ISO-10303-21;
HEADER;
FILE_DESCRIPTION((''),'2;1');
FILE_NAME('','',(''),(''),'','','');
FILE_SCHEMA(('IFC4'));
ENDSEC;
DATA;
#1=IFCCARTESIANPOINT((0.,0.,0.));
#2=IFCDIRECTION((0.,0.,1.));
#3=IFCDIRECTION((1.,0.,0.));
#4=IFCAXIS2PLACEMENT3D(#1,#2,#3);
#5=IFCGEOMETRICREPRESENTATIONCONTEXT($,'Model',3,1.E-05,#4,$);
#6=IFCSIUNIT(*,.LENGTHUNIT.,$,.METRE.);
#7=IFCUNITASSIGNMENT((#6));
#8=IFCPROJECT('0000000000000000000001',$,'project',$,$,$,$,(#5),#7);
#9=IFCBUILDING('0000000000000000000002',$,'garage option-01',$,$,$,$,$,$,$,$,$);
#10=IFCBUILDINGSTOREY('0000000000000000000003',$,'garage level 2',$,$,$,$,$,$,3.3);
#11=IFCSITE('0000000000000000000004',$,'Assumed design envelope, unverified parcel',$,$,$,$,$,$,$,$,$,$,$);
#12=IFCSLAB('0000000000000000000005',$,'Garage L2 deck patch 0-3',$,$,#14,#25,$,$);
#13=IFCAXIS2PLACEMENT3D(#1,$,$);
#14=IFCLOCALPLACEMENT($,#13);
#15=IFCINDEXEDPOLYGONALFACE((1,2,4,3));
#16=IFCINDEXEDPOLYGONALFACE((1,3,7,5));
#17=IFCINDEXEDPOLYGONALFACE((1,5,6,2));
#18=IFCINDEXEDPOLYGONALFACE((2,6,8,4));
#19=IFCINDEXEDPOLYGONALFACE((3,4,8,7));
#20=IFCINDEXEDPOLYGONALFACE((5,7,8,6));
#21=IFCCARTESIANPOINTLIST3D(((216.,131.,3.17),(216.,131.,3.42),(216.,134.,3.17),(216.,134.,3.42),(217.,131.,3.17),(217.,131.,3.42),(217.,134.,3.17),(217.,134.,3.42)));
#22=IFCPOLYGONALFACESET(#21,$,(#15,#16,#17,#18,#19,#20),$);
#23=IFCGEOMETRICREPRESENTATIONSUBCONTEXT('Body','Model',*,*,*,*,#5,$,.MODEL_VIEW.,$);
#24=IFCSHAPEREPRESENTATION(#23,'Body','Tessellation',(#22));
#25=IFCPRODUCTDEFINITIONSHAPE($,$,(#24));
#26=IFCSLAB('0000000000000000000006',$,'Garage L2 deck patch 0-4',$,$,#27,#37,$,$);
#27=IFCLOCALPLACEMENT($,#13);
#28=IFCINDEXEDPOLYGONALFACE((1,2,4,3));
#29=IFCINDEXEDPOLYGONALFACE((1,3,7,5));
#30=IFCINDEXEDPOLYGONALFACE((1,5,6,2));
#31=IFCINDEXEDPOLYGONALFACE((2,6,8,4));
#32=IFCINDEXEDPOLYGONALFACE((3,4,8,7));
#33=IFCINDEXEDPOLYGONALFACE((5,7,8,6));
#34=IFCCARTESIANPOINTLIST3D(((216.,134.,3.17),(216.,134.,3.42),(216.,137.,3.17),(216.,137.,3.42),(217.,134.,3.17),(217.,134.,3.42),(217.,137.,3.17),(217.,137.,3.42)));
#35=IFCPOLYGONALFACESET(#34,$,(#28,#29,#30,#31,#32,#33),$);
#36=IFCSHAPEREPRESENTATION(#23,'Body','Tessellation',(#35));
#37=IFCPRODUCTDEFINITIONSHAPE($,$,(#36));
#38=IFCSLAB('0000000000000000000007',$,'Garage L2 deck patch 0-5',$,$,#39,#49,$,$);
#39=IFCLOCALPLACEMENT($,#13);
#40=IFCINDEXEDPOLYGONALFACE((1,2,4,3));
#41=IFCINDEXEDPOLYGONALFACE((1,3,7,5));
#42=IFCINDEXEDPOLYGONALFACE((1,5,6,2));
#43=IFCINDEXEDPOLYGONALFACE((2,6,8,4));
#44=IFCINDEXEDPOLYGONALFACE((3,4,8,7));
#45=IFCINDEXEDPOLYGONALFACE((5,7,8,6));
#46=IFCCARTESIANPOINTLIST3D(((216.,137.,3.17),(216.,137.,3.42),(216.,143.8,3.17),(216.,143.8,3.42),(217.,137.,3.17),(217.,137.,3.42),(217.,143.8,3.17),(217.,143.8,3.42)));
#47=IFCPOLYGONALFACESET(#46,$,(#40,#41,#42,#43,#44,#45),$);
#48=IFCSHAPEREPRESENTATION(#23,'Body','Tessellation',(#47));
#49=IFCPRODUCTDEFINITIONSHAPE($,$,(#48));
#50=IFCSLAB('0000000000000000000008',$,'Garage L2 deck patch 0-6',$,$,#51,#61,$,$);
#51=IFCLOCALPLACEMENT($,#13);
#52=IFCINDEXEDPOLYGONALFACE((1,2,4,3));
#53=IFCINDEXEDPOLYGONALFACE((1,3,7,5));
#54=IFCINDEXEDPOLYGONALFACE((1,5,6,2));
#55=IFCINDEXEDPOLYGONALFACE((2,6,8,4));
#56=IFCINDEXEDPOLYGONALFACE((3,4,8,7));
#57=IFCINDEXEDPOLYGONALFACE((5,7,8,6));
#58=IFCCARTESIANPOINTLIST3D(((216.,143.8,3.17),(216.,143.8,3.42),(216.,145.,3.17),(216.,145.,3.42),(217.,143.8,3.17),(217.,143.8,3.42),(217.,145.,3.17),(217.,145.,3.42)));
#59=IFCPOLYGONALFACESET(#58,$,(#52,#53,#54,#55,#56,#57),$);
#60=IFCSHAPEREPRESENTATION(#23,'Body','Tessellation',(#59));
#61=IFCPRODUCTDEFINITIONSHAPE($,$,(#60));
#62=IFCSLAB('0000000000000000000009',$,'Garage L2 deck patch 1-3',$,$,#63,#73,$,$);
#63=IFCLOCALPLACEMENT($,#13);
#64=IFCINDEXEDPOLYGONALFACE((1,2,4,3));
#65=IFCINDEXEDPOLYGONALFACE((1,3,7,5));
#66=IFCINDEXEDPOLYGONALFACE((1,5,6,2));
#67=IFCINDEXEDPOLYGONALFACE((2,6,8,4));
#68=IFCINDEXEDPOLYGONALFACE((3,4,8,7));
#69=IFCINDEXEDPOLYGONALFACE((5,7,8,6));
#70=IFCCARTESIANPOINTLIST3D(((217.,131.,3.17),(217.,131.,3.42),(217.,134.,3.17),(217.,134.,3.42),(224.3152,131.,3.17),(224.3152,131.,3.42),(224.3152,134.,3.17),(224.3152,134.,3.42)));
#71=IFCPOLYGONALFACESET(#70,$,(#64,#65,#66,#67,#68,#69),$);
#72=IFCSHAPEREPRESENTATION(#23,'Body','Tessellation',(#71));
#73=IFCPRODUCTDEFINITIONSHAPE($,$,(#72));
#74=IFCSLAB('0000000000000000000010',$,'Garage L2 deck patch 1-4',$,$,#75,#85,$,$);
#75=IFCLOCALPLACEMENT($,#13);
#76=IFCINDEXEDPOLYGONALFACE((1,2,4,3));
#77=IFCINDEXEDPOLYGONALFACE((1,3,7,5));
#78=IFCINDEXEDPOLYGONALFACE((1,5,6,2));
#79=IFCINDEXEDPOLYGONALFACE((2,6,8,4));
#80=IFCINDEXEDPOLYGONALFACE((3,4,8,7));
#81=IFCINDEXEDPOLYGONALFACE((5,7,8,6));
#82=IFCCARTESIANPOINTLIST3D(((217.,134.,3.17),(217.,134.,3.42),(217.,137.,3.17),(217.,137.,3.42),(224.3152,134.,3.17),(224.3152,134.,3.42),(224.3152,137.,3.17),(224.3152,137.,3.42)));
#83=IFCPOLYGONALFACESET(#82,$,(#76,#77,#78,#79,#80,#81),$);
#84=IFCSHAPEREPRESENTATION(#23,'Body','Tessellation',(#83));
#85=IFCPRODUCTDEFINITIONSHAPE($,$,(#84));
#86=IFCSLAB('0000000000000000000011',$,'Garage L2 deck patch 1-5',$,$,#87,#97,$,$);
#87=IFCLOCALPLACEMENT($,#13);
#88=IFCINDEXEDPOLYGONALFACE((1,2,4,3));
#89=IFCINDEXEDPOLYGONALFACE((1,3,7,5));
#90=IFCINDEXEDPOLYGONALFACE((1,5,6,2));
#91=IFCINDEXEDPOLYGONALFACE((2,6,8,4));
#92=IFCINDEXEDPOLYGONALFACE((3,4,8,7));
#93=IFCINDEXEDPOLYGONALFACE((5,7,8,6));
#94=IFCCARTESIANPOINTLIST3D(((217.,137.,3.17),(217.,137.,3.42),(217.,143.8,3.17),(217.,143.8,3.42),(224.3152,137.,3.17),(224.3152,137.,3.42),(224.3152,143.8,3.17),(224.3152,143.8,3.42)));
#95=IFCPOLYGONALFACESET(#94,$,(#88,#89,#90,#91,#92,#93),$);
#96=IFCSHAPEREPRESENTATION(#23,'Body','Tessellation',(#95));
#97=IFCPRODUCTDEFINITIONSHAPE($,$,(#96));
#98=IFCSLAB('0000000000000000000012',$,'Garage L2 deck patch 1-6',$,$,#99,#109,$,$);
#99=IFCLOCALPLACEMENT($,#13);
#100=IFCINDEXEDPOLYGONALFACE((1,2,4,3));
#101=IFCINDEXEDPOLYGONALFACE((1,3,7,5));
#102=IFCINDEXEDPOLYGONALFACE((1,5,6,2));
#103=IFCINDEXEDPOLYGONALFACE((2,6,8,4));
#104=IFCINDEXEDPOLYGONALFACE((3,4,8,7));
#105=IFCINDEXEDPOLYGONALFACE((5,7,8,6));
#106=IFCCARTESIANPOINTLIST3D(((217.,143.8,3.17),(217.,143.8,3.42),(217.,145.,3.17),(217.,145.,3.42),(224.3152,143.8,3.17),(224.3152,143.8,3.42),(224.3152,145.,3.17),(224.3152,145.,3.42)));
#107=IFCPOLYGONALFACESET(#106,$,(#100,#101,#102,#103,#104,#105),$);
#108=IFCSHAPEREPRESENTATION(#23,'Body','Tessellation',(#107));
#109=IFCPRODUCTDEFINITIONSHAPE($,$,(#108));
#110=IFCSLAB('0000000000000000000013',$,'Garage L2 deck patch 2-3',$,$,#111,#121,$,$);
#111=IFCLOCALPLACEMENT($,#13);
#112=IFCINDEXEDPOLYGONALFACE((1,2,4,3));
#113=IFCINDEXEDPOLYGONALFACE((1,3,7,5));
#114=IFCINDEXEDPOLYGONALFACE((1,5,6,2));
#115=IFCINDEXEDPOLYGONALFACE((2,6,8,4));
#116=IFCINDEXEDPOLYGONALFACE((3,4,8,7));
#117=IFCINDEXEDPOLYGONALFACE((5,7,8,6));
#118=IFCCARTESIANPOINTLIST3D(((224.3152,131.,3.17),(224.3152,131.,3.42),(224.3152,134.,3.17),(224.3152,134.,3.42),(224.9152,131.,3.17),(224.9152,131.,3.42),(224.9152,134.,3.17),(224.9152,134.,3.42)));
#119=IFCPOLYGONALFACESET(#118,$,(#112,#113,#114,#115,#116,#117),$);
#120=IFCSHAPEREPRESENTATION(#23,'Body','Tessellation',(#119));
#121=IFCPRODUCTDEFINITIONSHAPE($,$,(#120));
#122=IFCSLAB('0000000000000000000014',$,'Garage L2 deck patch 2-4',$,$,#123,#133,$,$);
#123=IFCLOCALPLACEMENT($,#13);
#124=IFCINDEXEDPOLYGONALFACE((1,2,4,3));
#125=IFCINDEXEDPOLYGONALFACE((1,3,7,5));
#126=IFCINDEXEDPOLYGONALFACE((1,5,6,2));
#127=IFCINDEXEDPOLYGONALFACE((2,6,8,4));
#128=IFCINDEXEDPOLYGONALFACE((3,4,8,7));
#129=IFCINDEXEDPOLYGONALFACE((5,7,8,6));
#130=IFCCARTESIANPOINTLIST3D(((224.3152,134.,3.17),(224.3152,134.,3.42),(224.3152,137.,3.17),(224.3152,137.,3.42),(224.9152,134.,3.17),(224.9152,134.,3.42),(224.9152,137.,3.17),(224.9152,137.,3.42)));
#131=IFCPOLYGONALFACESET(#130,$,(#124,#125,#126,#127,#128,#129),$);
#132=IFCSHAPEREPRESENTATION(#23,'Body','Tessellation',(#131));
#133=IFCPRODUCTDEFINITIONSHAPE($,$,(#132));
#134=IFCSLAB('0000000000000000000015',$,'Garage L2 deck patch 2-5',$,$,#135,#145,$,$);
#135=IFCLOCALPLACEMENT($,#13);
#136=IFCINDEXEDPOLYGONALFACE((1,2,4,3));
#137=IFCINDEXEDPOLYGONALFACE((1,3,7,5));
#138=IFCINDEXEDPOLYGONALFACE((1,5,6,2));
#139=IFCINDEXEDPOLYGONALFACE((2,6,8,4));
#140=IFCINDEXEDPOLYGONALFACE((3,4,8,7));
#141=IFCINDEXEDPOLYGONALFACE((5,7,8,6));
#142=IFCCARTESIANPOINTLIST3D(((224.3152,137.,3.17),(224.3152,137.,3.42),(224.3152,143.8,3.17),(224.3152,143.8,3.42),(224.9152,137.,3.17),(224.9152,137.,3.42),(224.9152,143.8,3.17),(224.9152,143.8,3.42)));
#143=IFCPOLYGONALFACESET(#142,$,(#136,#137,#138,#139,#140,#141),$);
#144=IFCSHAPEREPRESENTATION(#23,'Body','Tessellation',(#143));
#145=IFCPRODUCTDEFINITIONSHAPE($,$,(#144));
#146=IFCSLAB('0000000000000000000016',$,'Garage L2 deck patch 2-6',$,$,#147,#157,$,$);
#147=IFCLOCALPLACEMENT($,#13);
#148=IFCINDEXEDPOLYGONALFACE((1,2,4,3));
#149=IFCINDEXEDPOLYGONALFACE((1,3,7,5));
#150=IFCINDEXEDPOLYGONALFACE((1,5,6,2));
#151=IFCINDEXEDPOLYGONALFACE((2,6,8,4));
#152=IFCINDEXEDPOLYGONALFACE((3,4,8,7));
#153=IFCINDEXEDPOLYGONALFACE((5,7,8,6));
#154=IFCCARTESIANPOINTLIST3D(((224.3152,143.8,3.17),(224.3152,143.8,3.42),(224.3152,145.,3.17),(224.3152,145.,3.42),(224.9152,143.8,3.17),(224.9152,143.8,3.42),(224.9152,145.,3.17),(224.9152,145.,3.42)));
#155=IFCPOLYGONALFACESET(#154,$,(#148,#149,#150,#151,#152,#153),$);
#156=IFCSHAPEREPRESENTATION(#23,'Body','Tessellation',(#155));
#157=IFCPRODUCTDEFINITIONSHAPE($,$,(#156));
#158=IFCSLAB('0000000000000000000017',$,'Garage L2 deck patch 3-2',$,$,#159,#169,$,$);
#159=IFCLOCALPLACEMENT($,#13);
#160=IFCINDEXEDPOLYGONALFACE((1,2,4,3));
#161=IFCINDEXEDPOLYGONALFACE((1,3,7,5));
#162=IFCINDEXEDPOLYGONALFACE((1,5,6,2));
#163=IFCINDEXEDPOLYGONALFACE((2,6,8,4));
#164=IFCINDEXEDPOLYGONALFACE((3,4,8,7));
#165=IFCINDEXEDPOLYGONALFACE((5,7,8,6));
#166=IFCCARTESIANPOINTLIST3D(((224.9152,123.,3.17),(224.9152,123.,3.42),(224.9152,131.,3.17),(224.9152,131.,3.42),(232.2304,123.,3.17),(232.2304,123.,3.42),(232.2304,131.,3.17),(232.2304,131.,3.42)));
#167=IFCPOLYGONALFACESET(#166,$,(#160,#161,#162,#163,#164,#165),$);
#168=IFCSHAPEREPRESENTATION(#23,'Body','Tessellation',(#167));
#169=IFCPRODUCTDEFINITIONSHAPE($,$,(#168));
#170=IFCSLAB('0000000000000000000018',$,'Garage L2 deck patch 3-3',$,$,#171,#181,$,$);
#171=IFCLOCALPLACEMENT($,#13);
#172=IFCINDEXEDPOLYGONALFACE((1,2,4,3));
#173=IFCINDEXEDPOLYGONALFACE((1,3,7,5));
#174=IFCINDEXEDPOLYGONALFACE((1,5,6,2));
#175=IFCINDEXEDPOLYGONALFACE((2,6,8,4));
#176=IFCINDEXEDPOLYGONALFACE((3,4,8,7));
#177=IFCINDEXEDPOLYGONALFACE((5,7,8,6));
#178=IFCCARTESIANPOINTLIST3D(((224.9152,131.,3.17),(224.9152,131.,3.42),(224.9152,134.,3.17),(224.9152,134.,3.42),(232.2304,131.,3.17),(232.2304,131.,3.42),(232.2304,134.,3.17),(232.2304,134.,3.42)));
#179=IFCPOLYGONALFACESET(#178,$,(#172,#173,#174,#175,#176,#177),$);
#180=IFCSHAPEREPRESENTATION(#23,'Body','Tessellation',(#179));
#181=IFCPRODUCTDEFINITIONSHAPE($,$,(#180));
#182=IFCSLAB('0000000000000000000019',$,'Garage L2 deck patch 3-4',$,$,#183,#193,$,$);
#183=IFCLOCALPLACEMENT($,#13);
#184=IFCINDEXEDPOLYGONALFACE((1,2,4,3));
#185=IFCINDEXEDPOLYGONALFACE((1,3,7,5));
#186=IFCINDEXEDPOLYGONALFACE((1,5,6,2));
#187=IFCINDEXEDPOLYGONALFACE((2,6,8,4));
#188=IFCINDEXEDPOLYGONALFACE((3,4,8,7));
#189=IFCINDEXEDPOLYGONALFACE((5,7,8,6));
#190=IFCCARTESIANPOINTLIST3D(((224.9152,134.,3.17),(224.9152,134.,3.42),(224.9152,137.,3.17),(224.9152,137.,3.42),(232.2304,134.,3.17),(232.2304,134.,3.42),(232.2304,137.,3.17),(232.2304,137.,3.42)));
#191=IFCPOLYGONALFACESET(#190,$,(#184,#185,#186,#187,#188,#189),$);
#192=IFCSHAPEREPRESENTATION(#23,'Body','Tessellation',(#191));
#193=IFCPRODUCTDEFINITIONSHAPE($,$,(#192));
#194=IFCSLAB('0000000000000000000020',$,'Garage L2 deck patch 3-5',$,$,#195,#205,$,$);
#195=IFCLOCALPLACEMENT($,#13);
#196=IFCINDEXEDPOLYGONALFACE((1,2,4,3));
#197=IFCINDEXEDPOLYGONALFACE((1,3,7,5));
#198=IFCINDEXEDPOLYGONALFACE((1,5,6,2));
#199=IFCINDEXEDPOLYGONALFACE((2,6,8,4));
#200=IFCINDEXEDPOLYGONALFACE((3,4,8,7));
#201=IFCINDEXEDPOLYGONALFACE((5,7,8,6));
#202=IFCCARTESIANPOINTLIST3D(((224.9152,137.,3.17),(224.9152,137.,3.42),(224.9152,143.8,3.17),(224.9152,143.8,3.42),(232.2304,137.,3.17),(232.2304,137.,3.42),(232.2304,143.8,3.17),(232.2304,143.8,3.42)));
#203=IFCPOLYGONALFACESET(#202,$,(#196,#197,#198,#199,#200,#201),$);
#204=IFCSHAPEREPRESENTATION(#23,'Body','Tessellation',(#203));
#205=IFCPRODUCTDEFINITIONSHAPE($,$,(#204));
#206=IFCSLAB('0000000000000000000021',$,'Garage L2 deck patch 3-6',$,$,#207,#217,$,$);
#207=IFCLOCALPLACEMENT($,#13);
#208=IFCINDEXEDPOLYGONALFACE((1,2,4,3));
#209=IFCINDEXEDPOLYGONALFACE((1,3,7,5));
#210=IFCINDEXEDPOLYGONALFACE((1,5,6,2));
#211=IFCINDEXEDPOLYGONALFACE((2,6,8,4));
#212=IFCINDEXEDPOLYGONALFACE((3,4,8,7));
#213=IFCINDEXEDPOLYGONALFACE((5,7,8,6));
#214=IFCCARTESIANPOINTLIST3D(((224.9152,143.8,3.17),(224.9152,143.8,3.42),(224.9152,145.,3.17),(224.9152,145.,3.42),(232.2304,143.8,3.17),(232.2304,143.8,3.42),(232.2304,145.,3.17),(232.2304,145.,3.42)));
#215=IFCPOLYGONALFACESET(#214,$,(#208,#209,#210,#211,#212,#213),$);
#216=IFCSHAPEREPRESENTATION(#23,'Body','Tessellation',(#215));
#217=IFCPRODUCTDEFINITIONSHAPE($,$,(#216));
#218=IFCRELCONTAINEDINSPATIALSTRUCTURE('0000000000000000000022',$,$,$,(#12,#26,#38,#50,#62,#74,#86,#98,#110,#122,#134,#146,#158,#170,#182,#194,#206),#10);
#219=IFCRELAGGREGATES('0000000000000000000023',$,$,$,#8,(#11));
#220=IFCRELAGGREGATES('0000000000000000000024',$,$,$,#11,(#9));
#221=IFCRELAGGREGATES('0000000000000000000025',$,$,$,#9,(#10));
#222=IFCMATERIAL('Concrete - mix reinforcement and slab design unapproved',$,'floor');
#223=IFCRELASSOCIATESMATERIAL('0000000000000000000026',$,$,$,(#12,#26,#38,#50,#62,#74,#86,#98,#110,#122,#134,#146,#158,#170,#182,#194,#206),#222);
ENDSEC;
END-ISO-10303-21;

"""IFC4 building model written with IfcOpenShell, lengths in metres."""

from ifc_helpers import new_model, si_unit, frame, origin_with_axes, place, context, subcontext, project, spatial, rectangle, extrude, material, element, save


model = new_model("IFC4")

# Units and contexts
model_context = context("Model", 3, precision=1e-05, world=origin_with_axes())
body_context = subcontext(model_context, "Body", "Model", "MODEL_VIEW")
ifc_project = project(units=[si_unit("LENGTHUNIT", "METRE")], contexts=[model_context])

# Site, building, storey
site = spatial("IfcSite", under=ifc_project, Name="Assumed design envelope, unverified parcel")
building = spatial("IfcBuilding", under=site, Name="garage option-01")
storey = spatial("IfcBuildingStorey", under=building, Name="garage level 2", Elevation=3.3)

# Slabs
ifc_material_1 = material(Name="Concrete - mix reinforcement and slab design unapproved", Category="floor")
for number, where, z_axis, x_axis, name in (
    (1, (216.5, 132.5, 3.17), (0.0, 0.0, 1.0), (1.0, 0.0, 0.0), "Garage L2 deck patch 0-3"),
    (2, (216.5, 135.5, 3.17), (0.0, 0.0, 1.0), (1.0, 0.0, 0.0), "Garage L2 deck patch 0-4"),
):
    element("IfcSlab", number, at=place(None, frame(where, z_axis=z_axis, x_axis=x_axis)), inside=storey, material=ifc_material_1, Name=name, context=body_context, shape_type="SweptSolid", body=[
        extrude(rectangle(XDim=1.0, YDim=3.0), origin_with_axes(), (0.0, 0.0, 1.0), 0.25),
    ])
slab_1_placement = place(None, frame((216.5, 140.4, 3.17), z_axis=(0.0, 0.0, 1.0), x_axis=(1.0, 0.0, 0.0)))
element("IfcSlab", 3, at=slab_1_placement, inside=storey, material=ifc_material_1, Name="Garage L2 deck patch 0-5", context=body_context, shape_type="SweptSolid", body=[
    extrude(rectangle(XDim=1.0, YDim=6.8), origin_with_axes(), (0.0, 0.0, 1.0), 0.25),
])
slab_2_placement = place(None, frame((216.5, 144.4, 3.17), z_axis=(0.0, 0.0, 1.0), x_axis=(1.0, 0.0, 0.0)))
element("IfcSlab", 4, at=slab_2_placement, inside=storey, material=ifc_material_1, Name="Garage L2 deck patch 0-6", context=body_context, shape_type="SweptSolid", body=[
    extrude(rectangle(XDim=1.0, YDim=1.2), origin_with_axes(), (0.0, 0.0, 1.0), 0.25),
])
for number, where, z_axis, x_axis, name in (
    (5, (220.6576, 132.5, 3.17), (0.0, 0.0, 1.0), (1.0, 0.0, 0.0), "Garage L2 deck patch 1-3"),
    (6, (220.6576, 135.5, 3.17), (0.0, 0.0, 1.0), (1.0, 0.0, 0.0), "Garage L2 deck patch 1-4"),
):
    element("IfcSlab", number, at=place(None, frame(where, z_axis=z_axis, x_axis=x_axis)), inside=storey, material=ifc_material_1, Name=name, context=body_context, shape_type="SweptSolid", body=[
        extrude(rectangle(XDim=7.3152, YDim=3.0), origin_with_axes(), (0.0, 0.0, 1.0), 0.25),
    ])
slab_3_placement = place(None, frame((220.6576, 140.4, 3.17), z_axis=(0.0, 0.0, 1.0), x_axis=(1.0, 0.0, 0.0)))
element("IfcSlab", 7, at=slab_3_placement, inside=storey, material=ifc_material_1, Name="Garage L2 deck patch 1-5", context=body_context, shape_type="SweptSolid", body=[
    extrude(rectangle(XDim=7.3152, YDim=6.8), origin_with_axes(), (0.0, 0.0, 1.0), 0.25),
])
slab_4_placement = place(None, frame((220.6576, 144.4, 3.17), z_axis=(0.0, 0.0, 1.0), x_axis=(1.0, 0.0, 0.0)))
element("IfcSlab", 8, at=slab_4_placement, inside=storey, material=ifc_material_1, Name="Garage L2 deck patch 1-6", context=body_context, shape_type="SweptSolid", body=[
    extrude(rectangle(XDim=7.3152, YDim=1.2), origin_with_axes(), (0.0, 0.0, 1.0), 0.25),
])
for number, where, z_axis, x_axis, name in (
    (9, (224.6152, 132.5, 3.17), (0.0, 0.0, 1.0), (1.0, 0.0, 0.0), "Garage L2 deck patch 2-3"),
    (10, (224.6152, 135.5, 3.17), (0.0, 0.0, 1.0), (1.0, 0.0, 0.0), "Garage L2 deck patch 2-4"),
):
    element("IfcSlab", number, at=place(None, frame(where, z_axis=z_axis, x_axis=x_axis)), inside=storey, material=ifc_material_1, Name=name, context=body_context, shape_type="SweptSolid", body=[
        extrude(rectangle(XDim=0.6, YDim=3.0), origin_with_axes(), (0.0, 0.0, 1.0), 0.25),
    ])
slab_5_placement = place(None, frame((224.6152, 140.4, 3.17), z_axis=(0.0, 0.0, 1.0), x_axis=(1.0, 0.0, 0.0)))
element("IfcSlab", 11, at=slab_5_placement, inside=storey, material=ifc_material_1, Name="Garage L2 deck patch 2-5", context=body_context, shape_type="SweptSolid", body=[
    extrude(rectangle(XDim=0.6, YDim=6.8), origin_with_axes(), (0.0, 0.0, 1.0), 0.25),
])
slab_6_placement = place(None, frame((224.6152, 144.4, 3.17), z_axis=(0.0, 0.0, 1.0), x_axis=(1.0, 0.0, 0.0)))
element("IfcSlab", 12, at=slab_6_placement, inside=storey, material=ifc_material_1, Name="Garage L2 deck patch 2-6", context=body_context, shape_type="SweptSolid", body=[
    extrude(rectangle(XDim=0.6, YDim=1.2), origin_with_axes(), (0.0, 0.0, 1.0), 0.25),
])
slab_7_placement = place(None, frame((228.5728, 127.0, 3.17), z_axis=(0.0, 0.0, 1.0), x_axis=(1.0, 0.0, 0.0)))
element("IfcSlab", 13, at=slab_7_placement, inside=storey, material=ifc_material_1, Name="Garage L2 deck patch 3-2", context=body_context, shape_type="SweptSolid", body=[
    extrude(rectangle(XDim=7.3152, YDim=8.0), origin_with_axes(), (0.0, 0.0, 1.0), 0.25),
])
for number, where, z_axis, x_axis, name in (
    (14, (228.5728, 132.5, 3.17), (0.0, 0.0, 1.0), (1.0, 0.0, 0.0), "Garage L2 deck patch 3-3"),
    (15, (228.5728, 135.5, 3.17), (0.0, 0.0, 1.0), (1.0, 0.0, 0.0), "Garage L2 deck patch 3-4"),
):
    element("IfcSlab", number, at=place(None, frame(where, z_axis=z_axis, x_axis=x_axis)), inside=storey, material=ifc_material_1, Name=name, context=body_context, shape_type="SweptSolid", body=[
        extrude(rectangle(XDim=7.3152, YDim=3.0), origin_with_axes(), (0.0, 0.0, 1.0), 0.25),
    ])
slab_8_placement = place(None, frame((228.5728, 140.4, 3.17), z_axis=(0.0, 0.0, 1.0), x_axis=(1.0, 0.0, 0.0)))
element("IfcSlab", 16, at=slab_8_placement, inside=storey, material=ifc_material_1, Name="Garage L2 deck patch 3-5", context=body_context, shape_type="SweptSolid", body=[
    extrude(rectangle(XDim=7.3152, YDim=6.8), origin_with_axes(), (0.0, 0.0, 1.0), 0.25),
])
slab_9_placement = place(None, frame((228.5728, 144.4, 3.17), z_axis=(0.0, 0.0, 1.0), x_axis=(1.0, 0.0, 0.0)))
element("IfcSlab", 17, at=slab_9_placement, inside=storey, material=ifc_material_1, Name="Garage L2 deck patch 3-6", context=body_context, shape_type="SweptSolid", body=[
    extrude(rectangle(XDim=7.3152, YDim=1.2), origin_with_axes(), (0.0, 0.0, 1.0), 0.25),
])

save(model, "model.ifc")
